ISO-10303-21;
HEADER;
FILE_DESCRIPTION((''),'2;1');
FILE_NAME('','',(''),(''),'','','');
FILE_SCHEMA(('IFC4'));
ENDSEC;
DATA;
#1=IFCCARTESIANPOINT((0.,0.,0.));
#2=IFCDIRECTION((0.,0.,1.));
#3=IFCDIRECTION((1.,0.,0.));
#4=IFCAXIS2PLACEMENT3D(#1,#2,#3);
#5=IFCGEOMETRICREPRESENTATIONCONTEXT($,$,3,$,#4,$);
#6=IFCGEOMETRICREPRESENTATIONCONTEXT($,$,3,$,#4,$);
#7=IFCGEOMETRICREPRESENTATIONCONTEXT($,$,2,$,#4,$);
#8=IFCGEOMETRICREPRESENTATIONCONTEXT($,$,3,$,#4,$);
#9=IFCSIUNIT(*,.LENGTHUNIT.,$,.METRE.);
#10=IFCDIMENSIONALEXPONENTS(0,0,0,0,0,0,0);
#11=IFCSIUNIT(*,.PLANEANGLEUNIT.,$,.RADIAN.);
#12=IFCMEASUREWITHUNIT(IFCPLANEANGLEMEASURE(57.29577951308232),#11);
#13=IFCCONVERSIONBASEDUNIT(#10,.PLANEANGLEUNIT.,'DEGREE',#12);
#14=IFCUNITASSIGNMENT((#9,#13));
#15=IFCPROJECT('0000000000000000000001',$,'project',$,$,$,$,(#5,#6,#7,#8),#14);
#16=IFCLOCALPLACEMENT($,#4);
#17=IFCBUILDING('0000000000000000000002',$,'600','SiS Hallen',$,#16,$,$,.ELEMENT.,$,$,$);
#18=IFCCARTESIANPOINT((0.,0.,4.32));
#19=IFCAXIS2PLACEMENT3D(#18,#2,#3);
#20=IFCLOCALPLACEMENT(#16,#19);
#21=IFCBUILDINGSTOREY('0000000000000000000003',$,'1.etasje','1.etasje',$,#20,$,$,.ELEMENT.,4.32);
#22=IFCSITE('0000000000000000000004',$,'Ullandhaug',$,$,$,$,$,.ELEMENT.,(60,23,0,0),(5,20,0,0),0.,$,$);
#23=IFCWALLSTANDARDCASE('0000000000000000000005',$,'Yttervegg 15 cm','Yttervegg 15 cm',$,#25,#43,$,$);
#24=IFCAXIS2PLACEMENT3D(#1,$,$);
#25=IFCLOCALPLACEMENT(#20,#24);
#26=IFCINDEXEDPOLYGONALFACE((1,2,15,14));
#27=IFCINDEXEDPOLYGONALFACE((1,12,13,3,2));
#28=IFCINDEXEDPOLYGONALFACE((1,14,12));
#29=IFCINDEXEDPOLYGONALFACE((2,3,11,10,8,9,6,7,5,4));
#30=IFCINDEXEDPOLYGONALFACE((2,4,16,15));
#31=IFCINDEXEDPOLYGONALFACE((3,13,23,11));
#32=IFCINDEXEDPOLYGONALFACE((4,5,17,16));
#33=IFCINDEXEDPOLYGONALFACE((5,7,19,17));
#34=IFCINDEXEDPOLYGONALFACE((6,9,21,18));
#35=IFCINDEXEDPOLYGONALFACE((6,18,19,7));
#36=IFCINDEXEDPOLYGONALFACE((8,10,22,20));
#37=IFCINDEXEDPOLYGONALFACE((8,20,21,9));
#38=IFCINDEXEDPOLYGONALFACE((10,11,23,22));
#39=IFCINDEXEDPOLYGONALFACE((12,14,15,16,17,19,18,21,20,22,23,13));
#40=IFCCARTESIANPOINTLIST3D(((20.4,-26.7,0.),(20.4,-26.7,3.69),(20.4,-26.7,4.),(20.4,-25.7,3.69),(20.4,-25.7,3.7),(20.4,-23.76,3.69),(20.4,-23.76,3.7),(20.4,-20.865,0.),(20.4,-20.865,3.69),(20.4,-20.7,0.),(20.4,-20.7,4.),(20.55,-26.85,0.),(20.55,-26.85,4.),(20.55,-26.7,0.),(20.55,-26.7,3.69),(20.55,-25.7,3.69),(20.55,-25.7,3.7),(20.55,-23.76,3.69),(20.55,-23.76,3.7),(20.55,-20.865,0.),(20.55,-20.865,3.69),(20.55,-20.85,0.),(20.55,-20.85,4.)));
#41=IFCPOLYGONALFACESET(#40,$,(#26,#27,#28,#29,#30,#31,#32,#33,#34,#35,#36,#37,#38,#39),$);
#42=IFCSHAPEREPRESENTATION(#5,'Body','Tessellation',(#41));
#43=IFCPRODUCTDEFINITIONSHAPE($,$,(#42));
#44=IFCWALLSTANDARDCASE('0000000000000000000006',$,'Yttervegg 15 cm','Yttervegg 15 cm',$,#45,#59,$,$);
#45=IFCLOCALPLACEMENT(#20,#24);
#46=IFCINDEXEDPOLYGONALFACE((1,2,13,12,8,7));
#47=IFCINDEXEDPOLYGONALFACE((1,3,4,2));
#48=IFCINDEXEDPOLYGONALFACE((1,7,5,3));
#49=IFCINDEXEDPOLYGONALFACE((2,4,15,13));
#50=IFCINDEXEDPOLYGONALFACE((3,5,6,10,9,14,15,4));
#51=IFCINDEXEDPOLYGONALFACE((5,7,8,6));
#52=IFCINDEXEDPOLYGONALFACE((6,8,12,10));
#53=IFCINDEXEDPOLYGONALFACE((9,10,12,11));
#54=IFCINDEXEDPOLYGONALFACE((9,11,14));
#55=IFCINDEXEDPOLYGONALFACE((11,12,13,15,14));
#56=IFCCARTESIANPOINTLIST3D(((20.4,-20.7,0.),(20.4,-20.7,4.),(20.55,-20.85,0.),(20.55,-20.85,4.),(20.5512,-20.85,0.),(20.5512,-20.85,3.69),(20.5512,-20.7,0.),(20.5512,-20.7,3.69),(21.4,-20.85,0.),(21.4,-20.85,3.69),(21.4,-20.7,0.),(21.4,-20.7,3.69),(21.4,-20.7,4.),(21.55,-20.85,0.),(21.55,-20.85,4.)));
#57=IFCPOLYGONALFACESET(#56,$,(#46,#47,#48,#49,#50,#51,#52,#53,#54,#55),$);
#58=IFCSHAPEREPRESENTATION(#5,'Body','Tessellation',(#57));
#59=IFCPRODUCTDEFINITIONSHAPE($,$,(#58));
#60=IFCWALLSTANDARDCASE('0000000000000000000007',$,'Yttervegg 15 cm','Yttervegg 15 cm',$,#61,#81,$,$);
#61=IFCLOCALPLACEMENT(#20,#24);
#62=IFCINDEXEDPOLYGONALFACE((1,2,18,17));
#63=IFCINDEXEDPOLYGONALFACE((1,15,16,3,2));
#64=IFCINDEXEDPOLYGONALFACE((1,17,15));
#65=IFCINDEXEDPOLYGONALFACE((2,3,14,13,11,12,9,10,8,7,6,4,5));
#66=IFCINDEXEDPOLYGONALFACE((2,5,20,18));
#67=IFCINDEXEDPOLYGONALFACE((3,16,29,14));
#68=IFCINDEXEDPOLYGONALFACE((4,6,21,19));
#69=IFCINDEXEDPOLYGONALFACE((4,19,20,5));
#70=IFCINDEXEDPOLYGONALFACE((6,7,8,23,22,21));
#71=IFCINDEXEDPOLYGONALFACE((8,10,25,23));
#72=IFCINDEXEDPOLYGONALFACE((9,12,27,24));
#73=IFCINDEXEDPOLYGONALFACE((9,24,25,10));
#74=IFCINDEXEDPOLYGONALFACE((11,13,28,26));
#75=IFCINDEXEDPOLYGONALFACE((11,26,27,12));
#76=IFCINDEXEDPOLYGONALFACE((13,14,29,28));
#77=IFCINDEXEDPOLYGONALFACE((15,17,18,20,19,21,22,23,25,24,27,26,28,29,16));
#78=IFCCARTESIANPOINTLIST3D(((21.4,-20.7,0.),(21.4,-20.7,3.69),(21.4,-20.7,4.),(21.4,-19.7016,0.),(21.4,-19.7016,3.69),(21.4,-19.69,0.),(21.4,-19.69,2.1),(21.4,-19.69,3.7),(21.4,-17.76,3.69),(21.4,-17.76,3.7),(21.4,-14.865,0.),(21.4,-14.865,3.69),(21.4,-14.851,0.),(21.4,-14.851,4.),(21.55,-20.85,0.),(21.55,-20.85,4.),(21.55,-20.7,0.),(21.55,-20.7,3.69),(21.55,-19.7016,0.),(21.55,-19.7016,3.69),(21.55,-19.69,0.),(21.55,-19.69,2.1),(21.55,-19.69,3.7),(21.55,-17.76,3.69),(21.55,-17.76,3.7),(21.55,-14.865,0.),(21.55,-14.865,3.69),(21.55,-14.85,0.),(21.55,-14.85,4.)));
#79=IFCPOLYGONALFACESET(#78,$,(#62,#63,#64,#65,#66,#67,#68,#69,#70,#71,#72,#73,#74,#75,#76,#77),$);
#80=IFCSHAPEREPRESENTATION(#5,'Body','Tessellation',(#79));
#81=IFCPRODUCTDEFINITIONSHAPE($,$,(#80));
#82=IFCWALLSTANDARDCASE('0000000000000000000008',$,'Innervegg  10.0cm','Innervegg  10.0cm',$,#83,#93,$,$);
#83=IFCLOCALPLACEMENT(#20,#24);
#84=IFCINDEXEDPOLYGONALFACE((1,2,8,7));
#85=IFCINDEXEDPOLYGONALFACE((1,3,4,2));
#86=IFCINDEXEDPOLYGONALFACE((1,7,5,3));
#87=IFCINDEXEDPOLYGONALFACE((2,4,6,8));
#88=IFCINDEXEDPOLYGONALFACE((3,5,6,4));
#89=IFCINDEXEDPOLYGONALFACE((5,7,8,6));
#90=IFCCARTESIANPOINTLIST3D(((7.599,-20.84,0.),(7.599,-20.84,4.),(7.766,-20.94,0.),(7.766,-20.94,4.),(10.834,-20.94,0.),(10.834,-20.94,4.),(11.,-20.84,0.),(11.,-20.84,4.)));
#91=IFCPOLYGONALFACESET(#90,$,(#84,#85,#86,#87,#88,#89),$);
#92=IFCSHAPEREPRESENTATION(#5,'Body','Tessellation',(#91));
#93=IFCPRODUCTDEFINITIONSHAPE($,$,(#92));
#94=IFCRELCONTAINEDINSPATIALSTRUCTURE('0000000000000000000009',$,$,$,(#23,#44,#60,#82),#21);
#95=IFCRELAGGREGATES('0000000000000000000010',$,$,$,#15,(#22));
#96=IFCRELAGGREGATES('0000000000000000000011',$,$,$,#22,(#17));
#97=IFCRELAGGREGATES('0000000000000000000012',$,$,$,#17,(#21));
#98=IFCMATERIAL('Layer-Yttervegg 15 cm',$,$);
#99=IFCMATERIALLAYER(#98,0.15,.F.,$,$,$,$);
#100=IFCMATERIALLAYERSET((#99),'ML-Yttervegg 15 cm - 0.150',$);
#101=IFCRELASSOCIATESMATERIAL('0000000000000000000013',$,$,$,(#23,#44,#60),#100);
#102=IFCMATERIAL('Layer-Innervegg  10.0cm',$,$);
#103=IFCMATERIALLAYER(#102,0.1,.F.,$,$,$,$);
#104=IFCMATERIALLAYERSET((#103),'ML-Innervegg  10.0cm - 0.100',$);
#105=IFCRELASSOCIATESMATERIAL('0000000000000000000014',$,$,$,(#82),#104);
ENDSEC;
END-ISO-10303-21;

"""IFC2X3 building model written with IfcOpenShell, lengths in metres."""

from ifc_helpers import new_model, entity, si_unit, converted_unit, frame, origin_with_axes, place, context, project, spatial, polyline, outline, extrude, material, layer, layer_set, layer_usage, element, save


model = new_model("IFC2X3")

# Units and contexts
context_of_model_1 = context(None, 3, world=origin_with_axes())
context_of_model_2 = context(None, 3, world=origin_with_axes())
context_of_model_3 = context(None, 2, world=origin_with_axes())
context_of_model_4 = context(None, 3, world=origin_with_axes())
ifc_project = project(units=[si_unit("LENGTHUNIT", "METRE"), converted_unit("PLANEANGLEUNIT", "DEGREE", entity("IfcPlaneAngleMeasure", 57.29577951308232), si_unit("PLANEANGLEUNIT", "RADIAN"), dimensions=[0, 0, 0, 0, 0, 0, 0])], contexts=[context_of_model_1, context_of_model_2, context_of_model_3, context_of_model_4])

# Site, building, storey
site = spatial("IfcSite", under=ifc_project, Name="Ullandhaug", CompositionType="ELEMENT", RefLatitude=(60, 23, 0, 0), RefLongitude=(5, 20, 0, 0), RefElevation=0.0)
building_placement = place(None, origin_with_axes())
building = spatial("IfcBuilding", under=site, at=building_placement, Name="600", Description="SiS Hallen", CompositionType="ELEMENT")
storey_placement = place(building_placement, frame((0.0, 0.0, 4.32), z_axis=(0.0, 0.0, 1.0), x_axis=(1.0, 0.0, 0.0)))
storey = spatial("IfcBuildingStorey", under=building, at=storey_placement, Name="1.etasje", Description="1.etasje", CompositionType="ELEMENT", Elevation=4.32)

# Shared definitions
ifc_material_1 = material(Name="Layer-Yttervegg 15 cm")
ifc_layer_1 = layer(ifc_material_1, 0.15, ventilated=False)
ifc_layer_set_1 = layer_set([ifc_layer_1], Name="ML-Yttervegg 15 cm - 0.150")
ifc_layer_usage_1 = layer_usage(ifc_layer_set_1, "AXIS2", "POSITIVE", 0.0)

# Wall, openings
wall_1_placement = place(storey_placement, frame((20.55, -26.85, 0.0), z_axis=(0.0, 0.0, 1.0), x_axis=(0.0, 1.0, 0.0)))
wall_1 = element("IfcWallStandardCase", 1, at=wall_1_placement, inside=storey, material=ifc_layer_usage_1, Name="Yttervegg 15 cm", Description="Yttervegg 15 cm", context=context_of_model_1, shape_type="SweptSolid", body=[
    extrude(outline(polyline([(0.0, 0.0), (6.0, 0.0), (6.15, 0.15), (0.15, 0.15), (0.0, 0.0)])), frame((0.0, 0.0, 0.0), z_axis=(0.0, 0.0, 1.0), x_axis=(1.0, 0.0, 0.0)), (0.0, 0.0, 1.0), 4.0),
])
opening_1_placement = place(wall_1_placement, frame((0.15, 0.15, 0.0), z_axis=(0.0, 0.0, 1.0), x_axis=(1.0, 0.0, 0.0)))
element("IfcOpeningElement", 2, at=opening_1_placement, cuts=wall_1, context=context_of_model_1, shape_type="SweptSolid", body=[
    extrude(outline(polyline([(0.0, 0.0), (3.69, 0.0), (3.69, 1.0), (0.0, 1.0), (0.0, 0.0)])), frame((0.0, 0.0, 0.0), z_axis=(0.0, 1.0, 0.0), x_axis=(0.0, 0.0, 1.0)), (0.0, 0.0, -1.0), 0.15),
])
opening_2_placement = place(wall_1_placement, frame((3.09, 0.15, 0.0), z_axis=(0.0, 0.0, 1.0), x_axis=(1.0, 0.0, 0.0)))
element("IfcOpeningElement", 3, at=opening_2_placement, cuts=wall_1, context=context_of_model_1, shape_type="SweptSolid", body=[
    extrude(outline(polyline([(0.0, 0.0), (3.69, 0.0), (3.69, 2.895), (0.0, 2.895), (0.0, 0.0)])), frame((0.0, 0.0, 0.0), z_axis=(0.0, 1.0, 0.0), x_axis=(0.0, 0.0, 1.0)), (0.0, 0.0, -1.0), 0.15),
])
opening_3_placement = place(wall_1_placement, frame((1.15, 0.15, 0.0), z_axis=(0.0, 0.0, 1.0), x_axis=(1.0, 0.0, 0.0)))
element("IfcOpeningElement", 4, at=opening_3_placement, cuts=wall_1, context=context_of_model_1, shape_type="SweptSolid", body=[
    extrude(outline(polyline([(0.0, 0.0), (2.1, 0.0), (2.1, 1.94), (0.0, 1.94), (0.0, 0.0)])), frame((0.0, 0.0, 0.0), z_axis=(0.0, 1.0, 0.0), x_axis=(0.0, 0.0, 1.0)), (0.0, 0.0, -1.0), 0.15),
])
opening_4_placement = place(wall_1_placement, frame((1.15, 0.15, 2.1), z_axis=(0.0, 0.0, 1.0), x_axis=(1.0, 0.0, 0.0)))
element("IfcOpeningElement", 5, at=opening_4_placement, cuts=wall_1, context=context_of_model_1, shape_type="SweptSolid", body=[
    extrude(outline(polyline([(0.0, 0.0), (1.6, 0.0), (1.6, 1.94), (0.0, 1.94), (0.0, 0.0)])), frame((0.0, 0.0, 0.0), z_axis=(0.0, 1.0, 0.0), x_axis=(0.0, 0.0, 1.0)), (0.0, 0.0, -1.0), 0.15),
])

# Wall, opening
wall_2_placement = place(storey_placement, frame((20.55, -20.85, 0.0), z_axis=(0.0, 0.0, 1.0), x_axis=(1.0, 0.0, 0.0)))
wall_2 = element("IfcWallStandardCase", 6, at=wall_2_placement, inside=storey, material=ifc_layer_usage_1, Name="Yttervegg 15 cm", Description="Yttervegg 15 cm", context=context_of_model_1, shape_type="SweptSolid", body=[
    extrude(outline(polyline([(0.0, 0.0), (1.0, 0.0), (0.85, 0.15), (-0.15, 0.15), (0.0, 0.0)])), origin_with_axes(), (0.0, 0.0, 1.0), 4.0),
])
opening_5_placement = place(wall_2_placement, frame((0.0012, 0.15, 0.0), z_axis=(0.0, 0.0, 1.0), x_axis=(1.0, 0.0, 0.0)))
element("IfcOpeningElement", 7, at=opening_5_placement, cuts=wall_2, context=context_of_model_1, shape_type="SweptSolid", body=[
    extrude(outline(polyline([(0.0, 0.0), (3.69, 0.0), (3.69, 0.8488), (0.0, 0.8488), (0.0, 0.0)])), frame((0.0, 0.0, 0.0), z_axis=(0.0, 1.0, 0.0), x_axis=(0.0, 0.0, 1.0)), (0.0, 0.0, -1.0), 0.15),
])

# Wall, openings
wall_3_placement = place(storey_placement, frame((21.55, -20.85, 0.0), z_axis=(0.0, 0.0, 1.0), x_axis=(0.0, 1.0, 0.0)))
wall_3 = element("IfcWallStandardCase", 8, at=wall_3_placement, inside=storey, material=ifc_layer_usage_1, Name="Yttervegg 15 cm", Description="Yttervegg 15 cm", context=context_of_model_1, shape_type="SweptSolid", body=[
    extrude(outline(polyline([(0.0, 0.0), (6.0, 0.0), (5.999, 0.15), (0.15, 0.15), (0.0, 0.0)])), frame((0.0, 0.0, 0.0), z_axis=(0.0, 0.0, 1.0), x_axis=(1.0, 0.0, 0.0)), (0.0, 0.0, 1.0), 4.0),
])
opening_6_placement = place(wall_3_placement, frame((0.15, 0.15, 0.0), z_axis=(0.0, 0.0, 1.0), x_axis=(1.0, 0.0, 0.0)))
element("IfcOpeningElement", 9, at=opening_6_placement, cuts=wall_3, context=context_of_model_1, shape_type="SweptSolid", body=[
    extrude(outline(polyline([(0.0, 0.0), (3.69, 0.0), (3.69, 0.9984), (0.0, 0.9984), (0.0, 0.0)])), frame((0.0, 0.0, 0.0), z_axis=(0.0, 1.0, 0.0), x_axis=(0.0, 0.0, 1.0)), (0.0, 0.0, -1.0), 0.15),
])
opening_7_placement = place(wall_3_placement, frame((3.09, 0.15, 0.0), z_axis=(0.0, 0.0, 1.0), x_axis=(1.0, 0.0, 0.0)))
element("IfcOpeningElement", 10, at=opening_7_placement, cuts=wall_3, context=context_of_model_1, shape_type="SweptSolid", body=[
    extrude(outline(polyline([(0.0, 0.0), (3.69, 0.0), (3.69, 2.895), (0.0, 2.895), (0.0, 0.0)])), frame((0.0, 0.0, 0.0), z_axis=(0.0, 1.0, 0.0), x_axis=(0.0, 0.0, 1.0)), (0.0, 0.0, -1.0), 0.15),
])
opening_8_placement = place(wall_3_placement, frame((1.16, 0.15, 0.0), z_axis=(0.0, 0.0, 1.0), x_axis=(1.0, 0.0, 0.0)))
element("IfcOpeningElement", 11, at=opening_8_placement, cuts=wall_3, context=context_of_model_1, shape_type="SweptSolid", body=[
    extrude(outline(polyline([(0.0, 0.0), (2.1, 0.0), (2.1, 2.0), (0.0, 2.0), (0.0, 0.0)])), frame((0.0, 0.0, 0.0), z_axis=(0.0, 1.0, 0.0), x_axis=(0.0, 0.0, 1.0)), (0.0, 0.0, -1.0), 0.15),
])
opening_9_placement = place(wall_3_placement, frame((1.16, 0.15, 2.1), z_axis=(0.0, 0.0, 1.0), x_axis=(1.0, 0.0, 0.0)))
element("IfcOpeningElement", 12, at=opening_9_placement, cuts=wall_3, context=context_of_model_1, shape_type="SweptSolid", body=[
    extrude(outline(polyline([(0.0, 0.0), (1.6, 0.0), (1.6, 1.93), (0.0, 1.93), (0.0, 0.0)])), frame((0.0, 0.0, 0.0), z_axis=(0.0, 1.0, 0.0), x_axis=(0.0, 0.0, 1.0)), (0.0, 0.0, -1.0), 0.15),
])

# Wall
ifc_material_2 = material(Name="Layer-Innervegg  10.0cm")
ifc_layer_2 = layer(ifc_material_2, 0.1, ventilated=False)
ifc_layer_set_2 = layer_set([ifc_layer_2], Name="ML-Innervegg  10.0cm - 0.100")
ifc_layer_usage_2 = layer_usage(ifc_layer_set_2, "AXIS2", "POSITIVE", 0.0)
wall_4_placement = place(storey_placement, frame((11.0, -20.84, 0.0), z_axis=(0.0, 0.0, 1.0), x_axis=(-1.0, 0.0, 0.0)))
element("IfcWallStandardCase", 13, at=wall_4_placement, inside=storey, material=ifc_layer_usage_2, Name="Innervegg  10.0cm", Description="Innervegg  10.0cm", context=context_of_model_1, shape_type="SweptSolid", body=[
    extrude(outline(polyline([(0.0, 0.0), (3.401, 0.0), (3.234, 0.1), (0.166, 0.1), (0.0, 0.0)])), frame((0.0, 0.0, 0.0), z_axis=(0.0, 0.0, 1.0), x_axis=(1.0, 0.0, 0.0)), (0.0, 0.0, 1.0), 4.0),
])

save(model, "model.ifc")
